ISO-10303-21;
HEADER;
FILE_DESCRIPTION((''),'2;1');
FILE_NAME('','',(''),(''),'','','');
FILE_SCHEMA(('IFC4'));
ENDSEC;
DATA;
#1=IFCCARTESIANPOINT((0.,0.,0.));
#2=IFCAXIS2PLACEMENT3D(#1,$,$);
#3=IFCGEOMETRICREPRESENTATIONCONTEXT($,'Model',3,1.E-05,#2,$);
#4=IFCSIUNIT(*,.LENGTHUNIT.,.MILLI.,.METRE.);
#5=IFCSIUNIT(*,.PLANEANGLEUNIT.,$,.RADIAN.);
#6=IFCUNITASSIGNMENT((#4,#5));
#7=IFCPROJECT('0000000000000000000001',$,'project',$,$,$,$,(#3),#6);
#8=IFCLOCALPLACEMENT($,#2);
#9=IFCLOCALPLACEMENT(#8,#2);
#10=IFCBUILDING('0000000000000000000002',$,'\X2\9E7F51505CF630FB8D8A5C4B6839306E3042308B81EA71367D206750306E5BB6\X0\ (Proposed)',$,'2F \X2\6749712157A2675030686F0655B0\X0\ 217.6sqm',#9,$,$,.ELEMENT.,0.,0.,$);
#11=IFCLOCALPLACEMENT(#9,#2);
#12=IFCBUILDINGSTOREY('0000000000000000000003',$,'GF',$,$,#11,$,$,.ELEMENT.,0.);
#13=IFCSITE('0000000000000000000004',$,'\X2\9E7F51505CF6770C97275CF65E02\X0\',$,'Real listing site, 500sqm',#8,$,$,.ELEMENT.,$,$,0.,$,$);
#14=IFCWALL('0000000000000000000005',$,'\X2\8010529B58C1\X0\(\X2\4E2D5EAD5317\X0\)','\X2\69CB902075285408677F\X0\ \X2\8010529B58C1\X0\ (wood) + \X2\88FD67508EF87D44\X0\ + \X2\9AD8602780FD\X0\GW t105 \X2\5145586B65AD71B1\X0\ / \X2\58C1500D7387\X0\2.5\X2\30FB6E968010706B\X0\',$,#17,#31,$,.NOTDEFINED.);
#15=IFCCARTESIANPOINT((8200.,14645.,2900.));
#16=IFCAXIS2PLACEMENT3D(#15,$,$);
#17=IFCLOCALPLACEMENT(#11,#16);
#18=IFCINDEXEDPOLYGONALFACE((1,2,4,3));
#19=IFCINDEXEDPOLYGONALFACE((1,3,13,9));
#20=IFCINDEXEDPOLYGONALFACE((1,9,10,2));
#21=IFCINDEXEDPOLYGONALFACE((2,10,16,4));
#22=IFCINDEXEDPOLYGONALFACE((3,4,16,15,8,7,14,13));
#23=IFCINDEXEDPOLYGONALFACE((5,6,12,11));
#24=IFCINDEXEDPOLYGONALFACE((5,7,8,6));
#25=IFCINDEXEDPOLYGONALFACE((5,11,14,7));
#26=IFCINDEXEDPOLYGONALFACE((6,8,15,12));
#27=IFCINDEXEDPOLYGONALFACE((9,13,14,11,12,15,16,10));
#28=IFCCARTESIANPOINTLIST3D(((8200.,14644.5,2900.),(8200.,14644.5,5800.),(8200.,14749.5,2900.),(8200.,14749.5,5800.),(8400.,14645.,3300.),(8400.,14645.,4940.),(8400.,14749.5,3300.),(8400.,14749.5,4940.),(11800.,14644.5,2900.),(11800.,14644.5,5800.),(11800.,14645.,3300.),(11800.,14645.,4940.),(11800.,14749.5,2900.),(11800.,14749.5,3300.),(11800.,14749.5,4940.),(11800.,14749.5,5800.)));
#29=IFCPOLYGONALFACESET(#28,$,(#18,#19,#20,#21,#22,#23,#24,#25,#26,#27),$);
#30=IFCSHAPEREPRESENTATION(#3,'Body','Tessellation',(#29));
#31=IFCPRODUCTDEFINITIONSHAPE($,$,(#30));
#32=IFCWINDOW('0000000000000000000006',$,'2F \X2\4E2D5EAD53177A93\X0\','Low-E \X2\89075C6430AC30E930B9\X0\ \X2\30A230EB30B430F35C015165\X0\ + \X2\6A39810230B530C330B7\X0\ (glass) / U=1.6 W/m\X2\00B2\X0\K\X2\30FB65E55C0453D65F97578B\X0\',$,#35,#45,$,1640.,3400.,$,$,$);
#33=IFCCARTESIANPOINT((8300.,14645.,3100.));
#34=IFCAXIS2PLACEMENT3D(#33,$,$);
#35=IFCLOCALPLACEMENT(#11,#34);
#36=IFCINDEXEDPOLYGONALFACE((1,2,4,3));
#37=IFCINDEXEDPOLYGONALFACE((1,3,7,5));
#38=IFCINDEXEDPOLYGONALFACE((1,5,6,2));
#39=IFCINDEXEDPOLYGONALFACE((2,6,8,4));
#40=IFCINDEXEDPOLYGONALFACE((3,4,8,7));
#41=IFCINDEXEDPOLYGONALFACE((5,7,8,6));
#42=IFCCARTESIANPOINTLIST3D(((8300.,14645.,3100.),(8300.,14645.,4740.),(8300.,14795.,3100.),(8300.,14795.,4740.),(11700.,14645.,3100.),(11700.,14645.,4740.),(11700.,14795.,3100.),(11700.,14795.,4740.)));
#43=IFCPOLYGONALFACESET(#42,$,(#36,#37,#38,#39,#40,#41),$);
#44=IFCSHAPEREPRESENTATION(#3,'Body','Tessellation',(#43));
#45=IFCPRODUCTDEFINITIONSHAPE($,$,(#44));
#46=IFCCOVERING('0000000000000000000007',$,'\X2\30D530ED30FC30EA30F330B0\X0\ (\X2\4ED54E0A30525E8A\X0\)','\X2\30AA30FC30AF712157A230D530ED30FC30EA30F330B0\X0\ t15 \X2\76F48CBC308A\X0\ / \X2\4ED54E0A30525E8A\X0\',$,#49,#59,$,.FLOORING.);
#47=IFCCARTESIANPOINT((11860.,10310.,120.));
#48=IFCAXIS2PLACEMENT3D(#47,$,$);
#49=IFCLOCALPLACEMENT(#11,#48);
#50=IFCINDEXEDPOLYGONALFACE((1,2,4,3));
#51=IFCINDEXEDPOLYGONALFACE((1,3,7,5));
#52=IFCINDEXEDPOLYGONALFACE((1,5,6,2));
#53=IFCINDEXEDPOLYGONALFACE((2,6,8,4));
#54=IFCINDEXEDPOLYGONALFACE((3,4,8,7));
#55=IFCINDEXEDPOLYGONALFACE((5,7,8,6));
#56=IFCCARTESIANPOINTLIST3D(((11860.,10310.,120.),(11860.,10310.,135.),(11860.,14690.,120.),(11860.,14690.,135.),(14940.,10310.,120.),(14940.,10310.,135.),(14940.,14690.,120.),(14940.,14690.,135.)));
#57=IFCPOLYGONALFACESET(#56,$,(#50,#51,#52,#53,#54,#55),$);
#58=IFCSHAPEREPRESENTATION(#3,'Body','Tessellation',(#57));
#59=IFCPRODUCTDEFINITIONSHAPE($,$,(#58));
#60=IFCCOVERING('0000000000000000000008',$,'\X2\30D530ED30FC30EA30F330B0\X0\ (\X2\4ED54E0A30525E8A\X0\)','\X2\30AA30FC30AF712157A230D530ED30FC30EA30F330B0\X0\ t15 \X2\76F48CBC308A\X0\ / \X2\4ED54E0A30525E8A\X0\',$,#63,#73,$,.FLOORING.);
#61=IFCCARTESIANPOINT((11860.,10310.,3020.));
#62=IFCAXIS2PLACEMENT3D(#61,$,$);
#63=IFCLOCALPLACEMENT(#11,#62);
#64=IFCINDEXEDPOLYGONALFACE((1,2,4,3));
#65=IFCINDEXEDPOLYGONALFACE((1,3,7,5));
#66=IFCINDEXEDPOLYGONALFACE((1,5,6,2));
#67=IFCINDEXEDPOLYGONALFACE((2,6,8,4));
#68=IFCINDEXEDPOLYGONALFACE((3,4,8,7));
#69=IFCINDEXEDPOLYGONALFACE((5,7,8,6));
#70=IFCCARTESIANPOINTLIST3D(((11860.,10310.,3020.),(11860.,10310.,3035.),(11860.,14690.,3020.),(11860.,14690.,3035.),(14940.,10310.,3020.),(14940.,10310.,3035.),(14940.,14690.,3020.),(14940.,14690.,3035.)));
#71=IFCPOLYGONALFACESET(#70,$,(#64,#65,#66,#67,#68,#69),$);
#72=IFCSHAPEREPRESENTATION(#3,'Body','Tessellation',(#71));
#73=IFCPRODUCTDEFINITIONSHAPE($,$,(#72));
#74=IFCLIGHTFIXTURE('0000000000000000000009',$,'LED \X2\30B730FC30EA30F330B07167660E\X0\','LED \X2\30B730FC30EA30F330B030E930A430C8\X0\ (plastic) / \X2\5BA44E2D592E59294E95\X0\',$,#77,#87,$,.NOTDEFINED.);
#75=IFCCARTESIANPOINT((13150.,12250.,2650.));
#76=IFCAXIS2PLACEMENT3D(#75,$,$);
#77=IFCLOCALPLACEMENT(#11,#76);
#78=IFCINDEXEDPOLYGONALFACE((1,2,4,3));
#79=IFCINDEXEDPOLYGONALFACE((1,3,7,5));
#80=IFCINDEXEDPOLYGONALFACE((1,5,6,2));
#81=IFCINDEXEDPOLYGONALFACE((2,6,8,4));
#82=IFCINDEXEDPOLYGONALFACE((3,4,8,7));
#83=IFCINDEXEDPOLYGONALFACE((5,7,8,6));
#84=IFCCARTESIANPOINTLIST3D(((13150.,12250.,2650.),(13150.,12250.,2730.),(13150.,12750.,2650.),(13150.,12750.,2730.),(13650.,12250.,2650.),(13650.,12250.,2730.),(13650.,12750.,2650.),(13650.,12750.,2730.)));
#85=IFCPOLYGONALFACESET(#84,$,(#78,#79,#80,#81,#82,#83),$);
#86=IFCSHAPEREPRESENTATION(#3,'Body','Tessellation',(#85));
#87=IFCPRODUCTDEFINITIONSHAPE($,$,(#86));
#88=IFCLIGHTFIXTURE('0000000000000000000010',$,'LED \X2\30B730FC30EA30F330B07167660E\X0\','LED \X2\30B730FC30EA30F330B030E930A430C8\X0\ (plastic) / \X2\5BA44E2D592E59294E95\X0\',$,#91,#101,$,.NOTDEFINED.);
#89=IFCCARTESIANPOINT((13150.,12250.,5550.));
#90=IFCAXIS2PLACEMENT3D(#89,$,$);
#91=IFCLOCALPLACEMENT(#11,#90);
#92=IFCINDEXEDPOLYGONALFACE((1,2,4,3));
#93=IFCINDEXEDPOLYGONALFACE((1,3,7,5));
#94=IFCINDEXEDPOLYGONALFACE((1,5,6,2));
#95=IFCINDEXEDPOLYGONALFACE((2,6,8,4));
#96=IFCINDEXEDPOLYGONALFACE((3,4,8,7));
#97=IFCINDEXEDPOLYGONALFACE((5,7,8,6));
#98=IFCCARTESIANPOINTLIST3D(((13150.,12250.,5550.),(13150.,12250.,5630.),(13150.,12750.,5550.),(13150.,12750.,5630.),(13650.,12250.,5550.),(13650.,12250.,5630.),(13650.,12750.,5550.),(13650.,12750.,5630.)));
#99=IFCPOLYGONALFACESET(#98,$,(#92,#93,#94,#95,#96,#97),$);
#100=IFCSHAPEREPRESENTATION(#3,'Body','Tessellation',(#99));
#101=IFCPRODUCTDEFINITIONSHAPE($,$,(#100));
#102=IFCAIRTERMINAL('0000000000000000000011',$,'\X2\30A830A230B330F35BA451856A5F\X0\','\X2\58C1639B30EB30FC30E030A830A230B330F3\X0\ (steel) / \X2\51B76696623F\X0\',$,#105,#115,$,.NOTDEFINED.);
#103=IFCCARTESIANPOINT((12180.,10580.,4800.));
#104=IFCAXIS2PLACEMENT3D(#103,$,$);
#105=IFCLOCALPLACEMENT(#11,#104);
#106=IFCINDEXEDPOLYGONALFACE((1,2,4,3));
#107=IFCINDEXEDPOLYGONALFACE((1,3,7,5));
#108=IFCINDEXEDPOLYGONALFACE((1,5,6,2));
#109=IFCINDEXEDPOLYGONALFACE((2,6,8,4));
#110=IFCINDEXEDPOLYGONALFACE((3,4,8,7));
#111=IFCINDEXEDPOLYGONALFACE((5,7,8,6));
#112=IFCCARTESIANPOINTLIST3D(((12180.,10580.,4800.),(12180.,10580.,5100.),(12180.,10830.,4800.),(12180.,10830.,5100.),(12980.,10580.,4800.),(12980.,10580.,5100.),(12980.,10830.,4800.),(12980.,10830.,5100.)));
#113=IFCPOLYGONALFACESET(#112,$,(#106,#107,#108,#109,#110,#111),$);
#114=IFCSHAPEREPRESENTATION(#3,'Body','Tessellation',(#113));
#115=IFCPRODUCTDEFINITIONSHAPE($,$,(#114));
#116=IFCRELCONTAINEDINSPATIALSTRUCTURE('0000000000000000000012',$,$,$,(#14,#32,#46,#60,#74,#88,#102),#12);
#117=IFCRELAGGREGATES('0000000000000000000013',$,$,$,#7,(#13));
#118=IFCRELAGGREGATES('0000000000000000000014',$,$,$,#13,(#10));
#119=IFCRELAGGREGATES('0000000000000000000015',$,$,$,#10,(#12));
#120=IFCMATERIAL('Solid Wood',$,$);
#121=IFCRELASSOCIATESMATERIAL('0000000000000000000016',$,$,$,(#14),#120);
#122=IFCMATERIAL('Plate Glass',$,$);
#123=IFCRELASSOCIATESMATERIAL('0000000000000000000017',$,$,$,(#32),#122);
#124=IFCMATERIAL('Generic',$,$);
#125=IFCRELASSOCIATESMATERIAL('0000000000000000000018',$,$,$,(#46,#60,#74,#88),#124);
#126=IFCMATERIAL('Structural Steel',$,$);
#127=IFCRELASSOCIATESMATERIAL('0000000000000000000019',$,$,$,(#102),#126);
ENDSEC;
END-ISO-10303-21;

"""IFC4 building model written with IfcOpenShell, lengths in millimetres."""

from ifc_helpers import new_model, si_unit, frame, frame_2d, origin, place, context, project, spatial, rectangle, extrude, material, element, fill, save


model = new_model("IFC4")

# Units and contexts
model_context = context("Model", 3, precision=1e-05, world=origin())
ifc_project = project(units=[si_unit("LENGTHUNIT", "METRE", prefix="MILLI"), si_unit("PLANEANGLEUNIT", "RADIAN")], contexts=[model_context])

# Site, building, storey
site_placement = place(None, origin())
site = spatial("IfcSite", under=ifc_project, at=site_placement, Name="鹿児島県霧島市", ObjectType="Real listing site, 500sqm", CompositionType="ELEMENT", RefElevation=0.0)
building_placement = place(site_placement, origin())
building = spatial("IfcBuilding", under=site, at=building_placement, Name="鹿児島・越屋根のある自然素材の家 (Proposed)", ObjectType="2F 杉無垢材と漆喰 217.6sqm", CompositionType="ELEMENT", ElevationOfRefHeight=0.0, ElevationOfTerrain=0.0)
storey_placement = place(building_placement, origin())
storey = spatial("IfcBuildingStorey", under=building, at=storey_placement, Name="GF", CompositionType="ELEMENT", Elevation=0.0)

# Shared definitions
ifc_material_1 = material(Name="Solid Wood")

# Wall, opening, window
ifc_material_2 = material(Name="Plate Glass")
wall_1_placement = place(storey_placement, frame((8200.0, 14645.0, 2900.0)))
wall_1 = element("IfcWall", 1, at=wall_1_placement, inside=storey, material=ifc_material_1, Name="耐力壁(中庭北)", Description="構造用合板 耐力壁 (wood) + 製材軸組 + 高性能GW t105 充填断熱 / 壁倍率2.5・準耐火", PredefinedType="NOTDEFINED", context=model_context, shape_type="SweptSolid", body=[
    extrude(rectangle(XDim=3600.0, YDim=105.0, at=frame_2d((1800.0, 52.0))), frame((8200.0, 14645.0, 2900.0)), (0.0, 0.0, 1.0), 2900.0),
])
opening_1_placement = place(storey_placement, frame((8300.0, 14645.0, 3100.0)))
opening_1 = element("IfcOpeningElement", 2, at=opening_1_placement, cuts=wall_1, PredefinedType="NOTDEFINED", context=model_context, shape_type="SweptSolid", body=[
    extrude(rectangle(XDim=3400.0, YDim=150.0, at=frame_2d((1700.0, 75.0))), frame((8300.0, 14645.0, 3100.0)), (0.0, 0.0, 1.0), 1640.0),
])
window_1_placement = place(storey_placement, frame((8300.0, 14645.0, 3100.0)))
window_1 = element("IfcWindow", 3, at=window_1_placement, inside=storey, material=ifc_material_2, Name="2F 中庭北窓", Description="Low-E 複層ガラス アルゴン封入 + 樹脂サッシ (glass) / U=1.6 W/m²K・日射取得型", OverallHeight=1640.0, OverallWidth=3400.0, context=model_context, shape_type="SweptSolid", body=[
    extrude(rectangle(XDim=3400.0, YDim=150.0, at=frame_2d((1700.0, 75.0))), frame((8300.0, 14645.0, 3100.0)), (0.0, 0.0, 1.0), 1640.0),
])
fill(opening_1, window_1)

# Coverings
ifc_material_3 = material(Name="Generic")
covering_1_placement = place(storey_placement, frame((11860.0, 10310.0, 120.0)))
element("IfcCovering", 4, at=covering_1_placement, inside=storey, material=ifc_material_3, Name="フローリング (仕上げ床)", Description="オーク無垢フローリング t15 直貼り / 仕上げ床", PredefinedType="FLOORING", context=model_context, shape_type="SweptSolid", body=[
    extrude(rectangle(XDim=3080.0, YDim=4380.0, at=frame_2d((1540.0, 2190.0))), frame((11860.0, 10310.0, 120.0)), (0.0, 0.0, 1.0), 15.0),
])
covering_2_placement = place(storey_placement, frame((11860.0, 10310.0, 3020.0)))
element("IfcCovering", 5, at=covering_2_placement, inside=storey, material=ifc_material_3, Name="フローリング (仕上げ床)", Description="オーク無垢フローリング t15 直貼り / 仕上げ床", PredefinedType="FLOORING", context=model_context, shape_type="SweptSolid", body=[
    extrude(rectangle(XDim=3080.0, YDim=4380.0, at=frame_2d((1540.0, 2190.0))), frame((11860.0, 10310.0, 3020.0)), (0.0, 0.0, 1.0), 15.0),
])

# Light fixtures
light_fixture_1_placement = place(storey_placement, frame((13150.0, 12250.0, 2650.0)))
element("IfcLightFixture", 6, at=light_fixture_1_placement, inside=storey, material=ifc_material_3, Name="LED シーリング照明", Description="LED シーリングライト (plastic) / 室中央天井", PredefinedType="NOTDEFINED", context=model_context, shape_type="SweptSolid", body=[
    extrude(rectangle(XDim=500.0, YDim=500.0, at=frame_2d((250.0, 250.0))), frame((13150.0, 12250.0, 2650.0)), (0.0, 0.0, 1.0), 80.0),
])
light_fixture_2_placement = place(storey_placement, frame((13150.0, 12250.0, 5550.0)))
element("IfcLightFixture", 7, at=light_fixture_2_placement, inside=storey, material=ifc_material_3, Name="LED シーリング照明", Description="LED シーリングライト (plastic) / 室中央天井", PredefinedType="NOTDEFINED", context=model_context, shape_type="SweptSolid", body=[
    extrude(rectangle(XDim=500.0, YDim=500.0, at=frame_2d((250.0, 250.0))), frame((13150.0, 12250.0, 5550.0)), (0.0, 0.0, 1.0), 80.0),
])

# Air terminal
ifc_material_4 = material(Name="Structural Steel")
air_terminal_placement = place(storey_placement, frame((12180.0, 10580.0, 4800.0)))
element("IfcAirTerminal", 8, at=air_terminal_placement, inside=storey, material=ifc_material_4, Name="エアコン室内機", Description="壁掛ルームエアコン (steel) / 冷暖房", PredefinedType="NOTDEFINED", context=model_context, shape_type="SweptSolid", body=[
    extrude(rectangle(XDim=800.0, YDim=250.0, at=frame_2d((400.0, 125.0))), frame((12180.0, 10580.0, 4800.0)), (0.0, 0.0, 1.0), 300.0),
])

save(model, "model.ifc")
